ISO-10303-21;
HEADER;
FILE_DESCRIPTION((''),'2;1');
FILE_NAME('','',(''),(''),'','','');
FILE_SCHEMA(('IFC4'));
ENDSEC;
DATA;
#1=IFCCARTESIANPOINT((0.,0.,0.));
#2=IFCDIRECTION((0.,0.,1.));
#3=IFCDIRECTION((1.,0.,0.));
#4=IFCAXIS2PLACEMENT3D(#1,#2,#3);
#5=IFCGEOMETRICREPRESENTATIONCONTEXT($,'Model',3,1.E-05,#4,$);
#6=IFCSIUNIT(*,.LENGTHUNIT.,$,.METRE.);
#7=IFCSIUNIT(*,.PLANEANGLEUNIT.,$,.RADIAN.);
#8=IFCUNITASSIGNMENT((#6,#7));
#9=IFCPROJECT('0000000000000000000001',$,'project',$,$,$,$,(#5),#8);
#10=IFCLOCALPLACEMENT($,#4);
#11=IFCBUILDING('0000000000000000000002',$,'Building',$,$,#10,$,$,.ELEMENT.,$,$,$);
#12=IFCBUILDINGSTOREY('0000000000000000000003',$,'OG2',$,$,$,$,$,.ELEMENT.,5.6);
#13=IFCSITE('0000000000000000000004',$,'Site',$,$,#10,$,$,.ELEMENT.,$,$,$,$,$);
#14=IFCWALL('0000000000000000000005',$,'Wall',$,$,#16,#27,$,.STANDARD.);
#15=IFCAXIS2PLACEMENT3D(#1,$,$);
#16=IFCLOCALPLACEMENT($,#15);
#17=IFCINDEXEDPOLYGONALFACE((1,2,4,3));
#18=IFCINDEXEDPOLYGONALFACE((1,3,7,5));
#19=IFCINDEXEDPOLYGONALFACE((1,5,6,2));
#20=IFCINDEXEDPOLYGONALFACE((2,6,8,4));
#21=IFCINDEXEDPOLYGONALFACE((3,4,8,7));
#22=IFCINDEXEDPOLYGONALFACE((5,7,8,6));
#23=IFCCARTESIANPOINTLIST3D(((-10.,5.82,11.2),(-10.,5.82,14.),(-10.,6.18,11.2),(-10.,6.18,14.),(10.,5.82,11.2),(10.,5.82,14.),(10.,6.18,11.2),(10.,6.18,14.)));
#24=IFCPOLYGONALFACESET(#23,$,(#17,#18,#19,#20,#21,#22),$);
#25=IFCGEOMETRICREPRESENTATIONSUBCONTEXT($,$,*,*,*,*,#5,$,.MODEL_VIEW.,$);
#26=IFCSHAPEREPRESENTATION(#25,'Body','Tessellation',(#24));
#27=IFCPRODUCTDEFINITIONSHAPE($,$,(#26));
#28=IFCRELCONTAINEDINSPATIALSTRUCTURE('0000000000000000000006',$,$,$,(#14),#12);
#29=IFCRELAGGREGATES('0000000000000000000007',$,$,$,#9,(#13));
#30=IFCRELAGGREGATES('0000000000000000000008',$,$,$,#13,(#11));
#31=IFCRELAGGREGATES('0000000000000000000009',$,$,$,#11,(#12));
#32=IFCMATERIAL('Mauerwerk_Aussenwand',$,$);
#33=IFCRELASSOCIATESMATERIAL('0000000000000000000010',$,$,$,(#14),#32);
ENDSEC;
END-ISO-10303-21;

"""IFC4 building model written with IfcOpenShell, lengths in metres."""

from ifc_helpers import new_model, si_unit, frame, frame_2d, origin, origin_with_axes, place, context, subcontext, project, spatial, rectangle, extrude, material, element, save


model = new_model("IFC4")

# Units and contexts
model_context = context("Model", 3, precision=1e-05, world=origin_with_axes())
sub_context = subcontext(model_context, None, None, "MODEL_VIEW")
ifc_project = project(units=[si_unit("LENGTHUNIT", "METRE"), si_unit("PLANEANGLEUNIT", "RADIAN")], contexts=[model_context])

# Site, building, storey
placement_1 = place(None, origin_with_axes())
site = spatial("IfcSite", under=ifc_project, at=placement_1, Name="Site", CompositionType="ELEMENT")
building = spatial("IfcBuilding", under=site, at=placement_1, Name="Building", CompositionType="ELEMENT")
storey = spatial("IfcBuildingStorey", under=building, Name="OG2", CompositionType="ELEMENT", Elevation=5.6)

# Wall
ifc_material = material(Name="Mauerwerk_Aussenwand")
placement_2 = place(None, origin_with_axes())
placement_3 = place(placement_2, frame((0.0, 0.0, 5.6)))
wall_placement = place(placement_3, frame((-10.0, 6.0, 5.6), x_axis=(1.0, 0.0, 0.0)))
element("IfcWall", 1, at=wall_placement, inside=storey, material=ifc_material, Name="Wall", PredefinedType="STANDARD", context=sub_context, shape_type="SweptSolid", body=[
    extrude(rectangle(XDim=20.0, YDim=0.36, at=frame_2d((10.0, 0.0))), origin(), (0.0, 0.0, 1.0), 2.8),
])

save(model, "model.ifc")
